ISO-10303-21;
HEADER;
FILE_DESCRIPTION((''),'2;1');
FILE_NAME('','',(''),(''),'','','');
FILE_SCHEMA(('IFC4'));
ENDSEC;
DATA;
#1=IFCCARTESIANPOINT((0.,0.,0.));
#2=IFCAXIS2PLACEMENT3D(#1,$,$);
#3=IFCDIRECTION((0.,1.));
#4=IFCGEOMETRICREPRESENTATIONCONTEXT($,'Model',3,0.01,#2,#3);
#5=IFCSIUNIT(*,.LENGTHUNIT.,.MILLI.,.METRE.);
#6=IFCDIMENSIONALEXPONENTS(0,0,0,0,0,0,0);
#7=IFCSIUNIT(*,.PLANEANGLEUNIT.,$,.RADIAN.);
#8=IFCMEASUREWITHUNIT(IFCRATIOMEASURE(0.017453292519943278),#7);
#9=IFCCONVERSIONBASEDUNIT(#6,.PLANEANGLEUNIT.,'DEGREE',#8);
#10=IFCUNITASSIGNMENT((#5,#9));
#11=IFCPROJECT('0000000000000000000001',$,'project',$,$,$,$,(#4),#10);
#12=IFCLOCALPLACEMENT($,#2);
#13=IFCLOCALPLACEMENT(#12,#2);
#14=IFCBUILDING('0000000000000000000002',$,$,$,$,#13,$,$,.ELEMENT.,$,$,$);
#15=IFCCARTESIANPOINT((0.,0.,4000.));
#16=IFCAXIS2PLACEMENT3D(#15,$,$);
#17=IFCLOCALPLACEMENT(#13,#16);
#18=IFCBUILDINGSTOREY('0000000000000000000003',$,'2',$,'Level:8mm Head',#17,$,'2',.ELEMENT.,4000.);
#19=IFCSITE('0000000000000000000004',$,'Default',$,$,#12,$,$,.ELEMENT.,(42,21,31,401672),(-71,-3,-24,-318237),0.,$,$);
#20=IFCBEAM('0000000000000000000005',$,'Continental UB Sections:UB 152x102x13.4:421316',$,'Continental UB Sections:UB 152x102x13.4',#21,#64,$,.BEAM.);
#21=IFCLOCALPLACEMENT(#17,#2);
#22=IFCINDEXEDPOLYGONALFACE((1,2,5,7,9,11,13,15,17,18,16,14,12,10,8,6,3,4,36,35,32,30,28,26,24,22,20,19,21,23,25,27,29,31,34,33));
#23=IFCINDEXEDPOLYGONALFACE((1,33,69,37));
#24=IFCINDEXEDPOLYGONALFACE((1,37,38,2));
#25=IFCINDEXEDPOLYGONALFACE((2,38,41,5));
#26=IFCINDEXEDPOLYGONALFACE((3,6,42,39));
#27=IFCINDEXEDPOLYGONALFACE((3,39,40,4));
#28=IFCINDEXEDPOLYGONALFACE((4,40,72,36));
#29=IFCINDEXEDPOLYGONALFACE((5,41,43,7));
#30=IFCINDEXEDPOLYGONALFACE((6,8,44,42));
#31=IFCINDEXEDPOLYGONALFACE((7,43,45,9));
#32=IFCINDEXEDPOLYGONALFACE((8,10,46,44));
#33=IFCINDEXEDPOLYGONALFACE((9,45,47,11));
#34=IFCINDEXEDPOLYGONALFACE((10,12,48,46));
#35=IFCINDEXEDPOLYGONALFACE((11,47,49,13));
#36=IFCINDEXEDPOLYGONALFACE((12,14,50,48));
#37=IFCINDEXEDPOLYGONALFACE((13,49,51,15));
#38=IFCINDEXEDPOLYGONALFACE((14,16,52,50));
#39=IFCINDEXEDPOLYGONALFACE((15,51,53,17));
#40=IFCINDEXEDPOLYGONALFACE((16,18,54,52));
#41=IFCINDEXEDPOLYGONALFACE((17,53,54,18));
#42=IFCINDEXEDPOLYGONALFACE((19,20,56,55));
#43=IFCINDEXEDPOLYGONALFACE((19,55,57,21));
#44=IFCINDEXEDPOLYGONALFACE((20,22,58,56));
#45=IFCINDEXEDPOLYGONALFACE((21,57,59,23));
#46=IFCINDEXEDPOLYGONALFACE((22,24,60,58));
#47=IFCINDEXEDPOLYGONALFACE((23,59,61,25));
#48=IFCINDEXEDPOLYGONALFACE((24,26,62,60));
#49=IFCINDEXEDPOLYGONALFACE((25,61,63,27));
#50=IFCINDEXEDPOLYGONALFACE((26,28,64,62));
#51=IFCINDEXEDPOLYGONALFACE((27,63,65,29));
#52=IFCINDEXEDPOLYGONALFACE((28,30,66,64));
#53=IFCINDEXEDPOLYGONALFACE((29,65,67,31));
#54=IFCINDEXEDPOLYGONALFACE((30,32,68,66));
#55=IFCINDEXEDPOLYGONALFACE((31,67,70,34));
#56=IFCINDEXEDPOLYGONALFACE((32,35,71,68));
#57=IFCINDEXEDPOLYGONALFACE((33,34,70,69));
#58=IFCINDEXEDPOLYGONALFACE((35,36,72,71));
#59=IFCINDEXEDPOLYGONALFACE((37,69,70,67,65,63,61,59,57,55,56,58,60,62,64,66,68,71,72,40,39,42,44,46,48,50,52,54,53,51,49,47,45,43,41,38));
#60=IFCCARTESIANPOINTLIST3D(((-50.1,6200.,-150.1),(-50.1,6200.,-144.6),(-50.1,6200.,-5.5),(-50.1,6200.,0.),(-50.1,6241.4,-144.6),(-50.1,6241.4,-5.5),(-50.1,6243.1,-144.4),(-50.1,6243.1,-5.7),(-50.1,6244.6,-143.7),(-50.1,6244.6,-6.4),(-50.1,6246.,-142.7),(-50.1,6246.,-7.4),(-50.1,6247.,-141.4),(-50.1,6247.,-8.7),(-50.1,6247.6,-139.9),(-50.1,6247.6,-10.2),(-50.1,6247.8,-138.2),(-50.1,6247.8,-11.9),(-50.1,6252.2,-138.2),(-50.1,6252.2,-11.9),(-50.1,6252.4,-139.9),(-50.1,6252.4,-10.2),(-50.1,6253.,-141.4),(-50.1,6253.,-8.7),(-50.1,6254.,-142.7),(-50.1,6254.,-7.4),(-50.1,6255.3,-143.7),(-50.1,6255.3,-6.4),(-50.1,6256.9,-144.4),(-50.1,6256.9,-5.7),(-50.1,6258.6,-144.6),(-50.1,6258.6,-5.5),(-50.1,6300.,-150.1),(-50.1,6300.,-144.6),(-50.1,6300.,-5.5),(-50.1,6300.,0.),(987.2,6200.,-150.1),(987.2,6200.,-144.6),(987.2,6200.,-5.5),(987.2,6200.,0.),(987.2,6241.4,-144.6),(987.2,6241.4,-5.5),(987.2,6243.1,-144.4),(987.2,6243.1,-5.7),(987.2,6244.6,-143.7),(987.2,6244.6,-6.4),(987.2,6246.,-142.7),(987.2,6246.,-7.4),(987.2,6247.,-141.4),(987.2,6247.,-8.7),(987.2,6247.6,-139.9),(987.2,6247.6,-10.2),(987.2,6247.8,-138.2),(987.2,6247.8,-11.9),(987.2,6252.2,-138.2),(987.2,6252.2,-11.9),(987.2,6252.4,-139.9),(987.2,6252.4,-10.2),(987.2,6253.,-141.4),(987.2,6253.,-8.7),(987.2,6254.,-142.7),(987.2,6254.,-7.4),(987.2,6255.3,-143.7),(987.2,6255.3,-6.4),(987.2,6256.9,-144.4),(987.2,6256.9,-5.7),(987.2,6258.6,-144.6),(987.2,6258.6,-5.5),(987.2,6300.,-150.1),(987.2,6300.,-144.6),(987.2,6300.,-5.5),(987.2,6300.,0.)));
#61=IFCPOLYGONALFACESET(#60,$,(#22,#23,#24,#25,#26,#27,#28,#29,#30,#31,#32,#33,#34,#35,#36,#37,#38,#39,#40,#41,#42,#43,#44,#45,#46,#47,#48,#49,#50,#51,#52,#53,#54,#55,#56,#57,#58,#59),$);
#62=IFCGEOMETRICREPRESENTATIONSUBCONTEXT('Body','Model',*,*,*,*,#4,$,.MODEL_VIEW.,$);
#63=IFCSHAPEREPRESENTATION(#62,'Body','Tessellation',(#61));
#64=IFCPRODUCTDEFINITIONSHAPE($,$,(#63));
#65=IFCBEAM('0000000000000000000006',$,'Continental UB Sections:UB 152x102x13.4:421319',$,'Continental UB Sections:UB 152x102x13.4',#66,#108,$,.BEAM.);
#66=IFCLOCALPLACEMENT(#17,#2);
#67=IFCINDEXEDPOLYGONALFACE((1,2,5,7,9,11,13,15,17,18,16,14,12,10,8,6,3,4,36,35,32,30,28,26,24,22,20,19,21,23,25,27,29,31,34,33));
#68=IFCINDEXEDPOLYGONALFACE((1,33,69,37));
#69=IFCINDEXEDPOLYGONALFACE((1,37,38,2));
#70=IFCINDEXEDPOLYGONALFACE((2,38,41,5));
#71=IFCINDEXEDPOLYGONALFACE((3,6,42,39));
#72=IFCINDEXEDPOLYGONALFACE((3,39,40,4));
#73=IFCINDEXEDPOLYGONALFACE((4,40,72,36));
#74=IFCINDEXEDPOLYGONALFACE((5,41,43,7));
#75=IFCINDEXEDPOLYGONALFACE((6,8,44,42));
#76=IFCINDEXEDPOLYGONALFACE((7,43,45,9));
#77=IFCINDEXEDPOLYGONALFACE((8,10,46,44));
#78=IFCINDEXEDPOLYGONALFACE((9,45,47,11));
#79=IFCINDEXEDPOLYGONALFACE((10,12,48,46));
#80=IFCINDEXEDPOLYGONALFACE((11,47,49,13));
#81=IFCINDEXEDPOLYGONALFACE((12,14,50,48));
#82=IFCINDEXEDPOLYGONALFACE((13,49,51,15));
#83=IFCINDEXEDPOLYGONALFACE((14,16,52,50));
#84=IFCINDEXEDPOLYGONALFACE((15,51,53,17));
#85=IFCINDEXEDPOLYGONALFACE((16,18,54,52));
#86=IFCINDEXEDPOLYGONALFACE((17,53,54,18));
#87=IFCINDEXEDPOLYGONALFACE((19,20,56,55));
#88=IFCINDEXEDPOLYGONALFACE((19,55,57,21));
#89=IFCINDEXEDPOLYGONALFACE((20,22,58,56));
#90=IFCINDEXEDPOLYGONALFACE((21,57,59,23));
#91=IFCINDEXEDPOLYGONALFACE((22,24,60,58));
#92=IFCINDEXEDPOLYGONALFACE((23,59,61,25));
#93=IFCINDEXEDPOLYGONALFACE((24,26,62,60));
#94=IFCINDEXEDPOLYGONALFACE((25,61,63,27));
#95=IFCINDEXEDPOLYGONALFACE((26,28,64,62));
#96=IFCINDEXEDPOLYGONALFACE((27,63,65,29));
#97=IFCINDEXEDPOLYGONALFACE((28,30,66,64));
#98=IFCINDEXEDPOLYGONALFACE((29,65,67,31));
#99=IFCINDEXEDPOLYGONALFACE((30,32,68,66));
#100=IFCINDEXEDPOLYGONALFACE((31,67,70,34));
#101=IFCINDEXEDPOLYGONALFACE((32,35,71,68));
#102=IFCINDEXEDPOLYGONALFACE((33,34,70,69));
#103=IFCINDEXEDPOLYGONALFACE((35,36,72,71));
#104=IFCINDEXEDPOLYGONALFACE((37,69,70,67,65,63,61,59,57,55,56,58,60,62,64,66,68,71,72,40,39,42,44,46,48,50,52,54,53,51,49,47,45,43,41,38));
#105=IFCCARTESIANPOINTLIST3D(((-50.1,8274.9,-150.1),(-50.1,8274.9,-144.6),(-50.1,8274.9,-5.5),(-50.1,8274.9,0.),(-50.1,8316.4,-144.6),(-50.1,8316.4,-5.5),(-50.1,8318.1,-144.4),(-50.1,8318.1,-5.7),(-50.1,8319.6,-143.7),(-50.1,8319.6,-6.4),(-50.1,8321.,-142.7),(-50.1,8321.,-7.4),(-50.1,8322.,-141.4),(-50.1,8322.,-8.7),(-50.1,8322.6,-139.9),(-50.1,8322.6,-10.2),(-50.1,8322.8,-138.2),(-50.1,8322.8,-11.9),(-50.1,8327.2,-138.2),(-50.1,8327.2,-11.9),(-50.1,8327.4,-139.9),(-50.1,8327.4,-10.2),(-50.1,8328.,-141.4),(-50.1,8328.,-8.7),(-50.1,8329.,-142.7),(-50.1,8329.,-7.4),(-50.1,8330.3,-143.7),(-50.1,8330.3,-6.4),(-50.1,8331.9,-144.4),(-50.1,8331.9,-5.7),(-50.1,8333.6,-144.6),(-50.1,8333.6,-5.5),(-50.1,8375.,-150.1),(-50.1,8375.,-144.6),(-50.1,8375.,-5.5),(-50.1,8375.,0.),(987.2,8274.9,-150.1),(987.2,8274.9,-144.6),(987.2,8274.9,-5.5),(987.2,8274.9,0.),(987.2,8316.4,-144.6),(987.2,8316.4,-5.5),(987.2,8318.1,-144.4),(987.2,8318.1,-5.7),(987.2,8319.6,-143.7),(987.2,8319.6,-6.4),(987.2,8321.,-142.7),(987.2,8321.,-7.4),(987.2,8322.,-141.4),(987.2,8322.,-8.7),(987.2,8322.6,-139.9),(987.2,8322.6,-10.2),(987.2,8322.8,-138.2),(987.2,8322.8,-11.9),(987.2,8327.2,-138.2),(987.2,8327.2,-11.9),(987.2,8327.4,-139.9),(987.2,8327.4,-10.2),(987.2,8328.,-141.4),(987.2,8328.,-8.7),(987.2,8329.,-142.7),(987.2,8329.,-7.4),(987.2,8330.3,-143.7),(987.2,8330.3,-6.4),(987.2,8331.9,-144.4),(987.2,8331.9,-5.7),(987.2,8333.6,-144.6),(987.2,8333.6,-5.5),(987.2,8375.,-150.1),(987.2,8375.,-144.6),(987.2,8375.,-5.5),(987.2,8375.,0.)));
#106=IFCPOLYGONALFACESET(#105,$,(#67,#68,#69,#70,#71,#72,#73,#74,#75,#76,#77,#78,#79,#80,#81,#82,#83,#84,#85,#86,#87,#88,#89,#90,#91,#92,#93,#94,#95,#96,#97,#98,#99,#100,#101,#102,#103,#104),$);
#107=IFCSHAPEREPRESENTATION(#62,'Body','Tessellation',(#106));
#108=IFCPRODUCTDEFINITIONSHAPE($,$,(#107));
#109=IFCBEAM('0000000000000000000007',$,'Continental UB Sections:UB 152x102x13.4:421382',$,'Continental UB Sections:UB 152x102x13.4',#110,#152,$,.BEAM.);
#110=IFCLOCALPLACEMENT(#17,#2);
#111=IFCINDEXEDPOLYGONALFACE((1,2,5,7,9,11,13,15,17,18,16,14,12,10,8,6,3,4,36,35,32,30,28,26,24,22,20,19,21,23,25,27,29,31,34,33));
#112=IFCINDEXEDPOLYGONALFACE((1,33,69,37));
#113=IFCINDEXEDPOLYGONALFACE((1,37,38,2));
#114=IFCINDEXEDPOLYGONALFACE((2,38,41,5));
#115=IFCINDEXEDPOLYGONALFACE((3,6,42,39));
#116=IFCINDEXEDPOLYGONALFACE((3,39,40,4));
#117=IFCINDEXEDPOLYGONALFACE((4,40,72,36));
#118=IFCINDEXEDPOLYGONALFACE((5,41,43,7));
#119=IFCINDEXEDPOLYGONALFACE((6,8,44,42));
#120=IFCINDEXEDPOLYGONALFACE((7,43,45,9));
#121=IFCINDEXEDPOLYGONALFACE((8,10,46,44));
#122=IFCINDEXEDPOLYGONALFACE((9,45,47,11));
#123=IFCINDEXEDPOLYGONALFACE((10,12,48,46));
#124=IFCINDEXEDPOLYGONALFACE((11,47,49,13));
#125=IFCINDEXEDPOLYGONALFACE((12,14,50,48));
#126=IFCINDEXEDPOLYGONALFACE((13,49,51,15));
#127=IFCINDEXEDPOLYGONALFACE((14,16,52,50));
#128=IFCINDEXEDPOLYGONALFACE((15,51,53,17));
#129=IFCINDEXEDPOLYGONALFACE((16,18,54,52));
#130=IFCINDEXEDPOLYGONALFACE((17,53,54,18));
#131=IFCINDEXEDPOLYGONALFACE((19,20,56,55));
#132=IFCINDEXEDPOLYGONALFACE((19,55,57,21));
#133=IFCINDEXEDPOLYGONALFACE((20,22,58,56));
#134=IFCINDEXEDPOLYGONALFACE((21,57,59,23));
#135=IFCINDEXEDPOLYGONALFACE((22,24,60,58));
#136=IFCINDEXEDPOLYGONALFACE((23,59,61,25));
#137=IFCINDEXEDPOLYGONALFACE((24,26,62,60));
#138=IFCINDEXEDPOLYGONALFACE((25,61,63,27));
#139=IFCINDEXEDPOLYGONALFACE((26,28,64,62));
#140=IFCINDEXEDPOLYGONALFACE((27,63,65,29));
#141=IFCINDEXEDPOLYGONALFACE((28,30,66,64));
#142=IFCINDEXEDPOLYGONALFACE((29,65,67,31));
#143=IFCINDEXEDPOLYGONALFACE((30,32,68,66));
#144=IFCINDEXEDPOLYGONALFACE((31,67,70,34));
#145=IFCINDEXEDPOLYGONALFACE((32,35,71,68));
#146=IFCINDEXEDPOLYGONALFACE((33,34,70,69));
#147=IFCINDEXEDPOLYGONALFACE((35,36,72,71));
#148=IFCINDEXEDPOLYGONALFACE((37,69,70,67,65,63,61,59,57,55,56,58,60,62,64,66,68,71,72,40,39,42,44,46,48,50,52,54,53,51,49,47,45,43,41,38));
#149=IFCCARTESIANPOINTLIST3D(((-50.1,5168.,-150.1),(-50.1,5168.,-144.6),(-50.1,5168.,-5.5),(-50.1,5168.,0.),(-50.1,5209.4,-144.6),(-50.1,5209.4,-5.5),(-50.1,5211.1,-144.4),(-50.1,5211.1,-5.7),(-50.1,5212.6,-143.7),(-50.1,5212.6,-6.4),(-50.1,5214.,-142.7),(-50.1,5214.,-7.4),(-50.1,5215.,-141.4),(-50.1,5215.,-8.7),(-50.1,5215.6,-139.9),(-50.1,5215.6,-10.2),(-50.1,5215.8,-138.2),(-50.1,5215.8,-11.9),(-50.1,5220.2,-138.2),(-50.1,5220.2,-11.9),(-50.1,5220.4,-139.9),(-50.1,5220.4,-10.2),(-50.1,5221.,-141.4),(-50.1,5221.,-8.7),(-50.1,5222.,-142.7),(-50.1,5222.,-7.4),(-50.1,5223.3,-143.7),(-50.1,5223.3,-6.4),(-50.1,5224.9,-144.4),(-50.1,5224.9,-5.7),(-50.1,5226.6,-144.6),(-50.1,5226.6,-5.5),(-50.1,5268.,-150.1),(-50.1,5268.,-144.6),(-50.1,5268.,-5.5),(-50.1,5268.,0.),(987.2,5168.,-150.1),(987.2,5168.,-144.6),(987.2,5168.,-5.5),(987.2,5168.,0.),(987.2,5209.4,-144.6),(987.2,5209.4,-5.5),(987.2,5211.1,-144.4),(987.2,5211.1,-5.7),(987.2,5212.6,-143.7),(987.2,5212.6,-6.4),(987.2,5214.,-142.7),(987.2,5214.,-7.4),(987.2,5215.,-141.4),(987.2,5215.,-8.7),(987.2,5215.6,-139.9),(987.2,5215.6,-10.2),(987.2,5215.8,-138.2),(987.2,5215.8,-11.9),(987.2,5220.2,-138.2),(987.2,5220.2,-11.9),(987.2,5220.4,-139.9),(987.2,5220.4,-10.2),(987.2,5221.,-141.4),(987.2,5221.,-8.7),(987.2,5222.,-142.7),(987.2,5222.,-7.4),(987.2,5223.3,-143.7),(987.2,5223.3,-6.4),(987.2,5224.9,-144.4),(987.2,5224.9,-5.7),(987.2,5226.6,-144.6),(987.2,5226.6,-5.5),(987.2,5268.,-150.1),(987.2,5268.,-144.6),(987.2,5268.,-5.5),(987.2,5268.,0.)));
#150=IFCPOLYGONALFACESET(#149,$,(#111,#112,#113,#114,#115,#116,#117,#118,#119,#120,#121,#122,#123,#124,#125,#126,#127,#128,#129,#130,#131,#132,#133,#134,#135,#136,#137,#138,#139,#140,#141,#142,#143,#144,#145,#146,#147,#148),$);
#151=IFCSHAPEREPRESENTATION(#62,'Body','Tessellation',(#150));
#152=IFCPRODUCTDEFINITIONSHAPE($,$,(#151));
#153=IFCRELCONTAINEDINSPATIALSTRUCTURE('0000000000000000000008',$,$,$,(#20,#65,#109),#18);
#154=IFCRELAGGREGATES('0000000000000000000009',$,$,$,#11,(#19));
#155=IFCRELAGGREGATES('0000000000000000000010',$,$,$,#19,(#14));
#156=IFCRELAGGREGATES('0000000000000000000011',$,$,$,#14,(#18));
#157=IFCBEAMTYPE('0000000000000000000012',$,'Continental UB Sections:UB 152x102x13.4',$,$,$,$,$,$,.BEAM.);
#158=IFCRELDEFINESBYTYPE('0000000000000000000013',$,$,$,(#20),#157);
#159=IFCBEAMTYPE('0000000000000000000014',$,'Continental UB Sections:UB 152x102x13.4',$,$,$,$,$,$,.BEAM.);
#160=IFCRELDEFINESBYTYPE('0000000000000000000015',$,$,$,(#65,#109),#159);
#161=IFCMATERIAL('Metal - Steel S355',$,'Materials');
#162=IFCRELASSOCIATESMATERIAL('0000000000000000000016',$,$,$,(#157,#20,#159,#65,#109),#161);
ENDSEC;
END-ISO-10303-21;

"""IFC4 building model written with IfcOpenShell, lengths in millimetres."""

from ifc_helpers import new_model, entity, si_unit, converted_unit, direction, frame, origin, place, context, subcontext, project, spatial, line, arc, indexed_curve, outline, extrude, source, transform, mapped, material, type_object, type_shapes, element, save


model = new_model("IFC4")

# Units and contexts
model_context = context("Model", 3, precision=0.01, world=origin(), true_north=direction((0.0, 1.0)))
body_context = subcontext(model_context, "Body", "Model", "MODEL_VIEW")
ifc_project = project(units=[si_unit("LENGTHUNIT", "METRE", prefix="MILLI"), converted_unit("PLANEANGLEUNIT", "DEGREE", entity("IfcRatioMeasure", 0.017453292519943278), si_unit("PLANEANGLEUNIT", "RADIAN"), dimensions=[0, 0, 0, 0, 0, 0, 0])], contexts=[model_context])

# Site, building, storey
site_placement = place(None, origin())
site = spatial("IfcSite", under=ifc_project, at=site_placement, Name="Default", CompositionType="ELEMENT", RefLatitude=(42, 21, 31, 401672), RefLongitude=(-71, -3, -24, -318237), RefElevation=0.0)
building_placement = place(site_placement, origin())
building = spatial("IfcBuilding", under=site, at=building_placement, CompositionType="ELEMENT")
storey_placement = place(building_placement, frame((0.0, 0.0, 4000.0)))
storey = spatial("IfcBuildingStorey", under=building, at=storey_placement, Name="2", ObjectType="Level:8mm Head", LongName="2", CompositionType="ELEMENT", Elevation=4000.0)

# Beams
ifc_material = material(Name="Metal - Steel S355", Category="Materials")
beam_type_1 = type_object("IfcBeamType", Name="Continental UB Sections:UB 152x102x13.4", PredefinedType="BEAM", material=ifc_material)
shared_shape_1 = source(origin(), body_context, "Body", "SweptSolid", [
    extrude(outline(indexed_curve([(-75.0, -50.1), (-69.6, -50.1), (-69.6, -8.5), (-67.7, -4.0), (-63.2, -2.1), (63.1, -2.1), (67.7, -4.0), (69.5, -8.5), (69.5, -50.1), (75.1, -50.1), (75.1, 50.1), (69.5, 50.1), (69.5, 8.6), (67.7, 4.0), (63.1, 2.2), (-63.2, 2.2), (-67.7, 4.0), (-69.6, 8.6), (-69.6, 50.0), (-75.0, 50.0)], segments=[line(1, 2, 3), arc(3, 4, 5), line(5, 6), arc(6, 7, 8), line(8, 9, 10, 11, 12, 13), arc(13, 14, 15), line(15, 16), arc(16, 17, 18), line(18, 19, 20, 1)], self_intersect=False)), frame((-550.1, 0.0, 0.0), z_axis=(1.0, 0.0, 0.0), x_axis=(0.0, 0.0, -1.0)), (0.0, 0.0, 1.0), 1037.3),
])
type_shapes(beam_type_1, [shared_shape_1])
beam_1_placement = place(storey_placement, frame((500.0, 6250.0, -75.1)))
element("IfcBeam", 1, at=beam_1_placement, inside=storey, type_object=beam_type_1, material=ifc_material, Name="Continental UB Sections:UB 152x102x13.4:421316", ObjectType="Continental UB Sections:UB 152x102x13.4", PredefinedType="BEAM", context=body_context, shape_type="MappedRepresentation", body=[
    mapped(shared_shape_1, transform((0.0, 0.0, 0.0), scale=1.0)),
])
beam_type_2 = type_object("IfcBeamType", Name="Continental UB Sections:UB 152x102x13.4", PredefinedType="BEAM", material=ifc_material)
shared_shape_2 = source(origin(), body_context, "Body", "SweptSolid", [
    extrude(outline(indexed_curve([(-75.0, -50.1), (-69.6, -50.1), (-69.6, -8.5), (-67.7, -4.0), (-63.2, -2.1), (63.1, -2.1), (67.7, -4.0), (69.5, -8.5), (69.5, -50.1), (75.1, -50.1), (75.1, 50.1), (69.5, 50.1), (69.5, 8.6), (67.7, 4.0), (63.1, 2.2), (-63.2, 2.2), (-67.7, 4.0), (-69.6, 8.6), (-69.6, 50.0), (-75.0, 50.0)], segments=[line(1, 2, 3), arc(3, 4, 5), line(5, 6), arc(6, 7, 8), line(8, 9, 10, 11, 12, 13), arc(13, 14, 15), line(15, 16), arc(16, 17, 18), line(18, 19, 20, 1)], self_intersect=False)), frame((-550.1, 0.0, 0.0), z_axis=(1.0, 0.0, 0.0), x_axis=(0.0, 0.0, -1.0)), (0.0, 0.0, 1.0), 1037.3),
])
type_shapes(beam_type_2, [shared_shape_2])
for number, where, name in (
    (2, (500.0, 8325.0, -75.1), "Continental UB Sections:UB 152x102x13.4:421319"),
    (3, (500.0, 5218.0, -75.1), "Continental UB Sections:UB 152x102x13.4:421382"),
):
    element("IfcBeam", number, at=place(storey_placement, frame(where)), inside=storey, type_object=beam_type_2, material=ifc_material, Name=name, ObjectType="Continental UB Sections:UB 152x102x13.4", PredefinedType="BEAM", context=body_context, shape_type="MappedRepresentation", body=[
        mapped(shared_shape_2, transform((0.0, 0.0, 0.0), scale=1.0)),
    ])

save(model, "model.ifc")
